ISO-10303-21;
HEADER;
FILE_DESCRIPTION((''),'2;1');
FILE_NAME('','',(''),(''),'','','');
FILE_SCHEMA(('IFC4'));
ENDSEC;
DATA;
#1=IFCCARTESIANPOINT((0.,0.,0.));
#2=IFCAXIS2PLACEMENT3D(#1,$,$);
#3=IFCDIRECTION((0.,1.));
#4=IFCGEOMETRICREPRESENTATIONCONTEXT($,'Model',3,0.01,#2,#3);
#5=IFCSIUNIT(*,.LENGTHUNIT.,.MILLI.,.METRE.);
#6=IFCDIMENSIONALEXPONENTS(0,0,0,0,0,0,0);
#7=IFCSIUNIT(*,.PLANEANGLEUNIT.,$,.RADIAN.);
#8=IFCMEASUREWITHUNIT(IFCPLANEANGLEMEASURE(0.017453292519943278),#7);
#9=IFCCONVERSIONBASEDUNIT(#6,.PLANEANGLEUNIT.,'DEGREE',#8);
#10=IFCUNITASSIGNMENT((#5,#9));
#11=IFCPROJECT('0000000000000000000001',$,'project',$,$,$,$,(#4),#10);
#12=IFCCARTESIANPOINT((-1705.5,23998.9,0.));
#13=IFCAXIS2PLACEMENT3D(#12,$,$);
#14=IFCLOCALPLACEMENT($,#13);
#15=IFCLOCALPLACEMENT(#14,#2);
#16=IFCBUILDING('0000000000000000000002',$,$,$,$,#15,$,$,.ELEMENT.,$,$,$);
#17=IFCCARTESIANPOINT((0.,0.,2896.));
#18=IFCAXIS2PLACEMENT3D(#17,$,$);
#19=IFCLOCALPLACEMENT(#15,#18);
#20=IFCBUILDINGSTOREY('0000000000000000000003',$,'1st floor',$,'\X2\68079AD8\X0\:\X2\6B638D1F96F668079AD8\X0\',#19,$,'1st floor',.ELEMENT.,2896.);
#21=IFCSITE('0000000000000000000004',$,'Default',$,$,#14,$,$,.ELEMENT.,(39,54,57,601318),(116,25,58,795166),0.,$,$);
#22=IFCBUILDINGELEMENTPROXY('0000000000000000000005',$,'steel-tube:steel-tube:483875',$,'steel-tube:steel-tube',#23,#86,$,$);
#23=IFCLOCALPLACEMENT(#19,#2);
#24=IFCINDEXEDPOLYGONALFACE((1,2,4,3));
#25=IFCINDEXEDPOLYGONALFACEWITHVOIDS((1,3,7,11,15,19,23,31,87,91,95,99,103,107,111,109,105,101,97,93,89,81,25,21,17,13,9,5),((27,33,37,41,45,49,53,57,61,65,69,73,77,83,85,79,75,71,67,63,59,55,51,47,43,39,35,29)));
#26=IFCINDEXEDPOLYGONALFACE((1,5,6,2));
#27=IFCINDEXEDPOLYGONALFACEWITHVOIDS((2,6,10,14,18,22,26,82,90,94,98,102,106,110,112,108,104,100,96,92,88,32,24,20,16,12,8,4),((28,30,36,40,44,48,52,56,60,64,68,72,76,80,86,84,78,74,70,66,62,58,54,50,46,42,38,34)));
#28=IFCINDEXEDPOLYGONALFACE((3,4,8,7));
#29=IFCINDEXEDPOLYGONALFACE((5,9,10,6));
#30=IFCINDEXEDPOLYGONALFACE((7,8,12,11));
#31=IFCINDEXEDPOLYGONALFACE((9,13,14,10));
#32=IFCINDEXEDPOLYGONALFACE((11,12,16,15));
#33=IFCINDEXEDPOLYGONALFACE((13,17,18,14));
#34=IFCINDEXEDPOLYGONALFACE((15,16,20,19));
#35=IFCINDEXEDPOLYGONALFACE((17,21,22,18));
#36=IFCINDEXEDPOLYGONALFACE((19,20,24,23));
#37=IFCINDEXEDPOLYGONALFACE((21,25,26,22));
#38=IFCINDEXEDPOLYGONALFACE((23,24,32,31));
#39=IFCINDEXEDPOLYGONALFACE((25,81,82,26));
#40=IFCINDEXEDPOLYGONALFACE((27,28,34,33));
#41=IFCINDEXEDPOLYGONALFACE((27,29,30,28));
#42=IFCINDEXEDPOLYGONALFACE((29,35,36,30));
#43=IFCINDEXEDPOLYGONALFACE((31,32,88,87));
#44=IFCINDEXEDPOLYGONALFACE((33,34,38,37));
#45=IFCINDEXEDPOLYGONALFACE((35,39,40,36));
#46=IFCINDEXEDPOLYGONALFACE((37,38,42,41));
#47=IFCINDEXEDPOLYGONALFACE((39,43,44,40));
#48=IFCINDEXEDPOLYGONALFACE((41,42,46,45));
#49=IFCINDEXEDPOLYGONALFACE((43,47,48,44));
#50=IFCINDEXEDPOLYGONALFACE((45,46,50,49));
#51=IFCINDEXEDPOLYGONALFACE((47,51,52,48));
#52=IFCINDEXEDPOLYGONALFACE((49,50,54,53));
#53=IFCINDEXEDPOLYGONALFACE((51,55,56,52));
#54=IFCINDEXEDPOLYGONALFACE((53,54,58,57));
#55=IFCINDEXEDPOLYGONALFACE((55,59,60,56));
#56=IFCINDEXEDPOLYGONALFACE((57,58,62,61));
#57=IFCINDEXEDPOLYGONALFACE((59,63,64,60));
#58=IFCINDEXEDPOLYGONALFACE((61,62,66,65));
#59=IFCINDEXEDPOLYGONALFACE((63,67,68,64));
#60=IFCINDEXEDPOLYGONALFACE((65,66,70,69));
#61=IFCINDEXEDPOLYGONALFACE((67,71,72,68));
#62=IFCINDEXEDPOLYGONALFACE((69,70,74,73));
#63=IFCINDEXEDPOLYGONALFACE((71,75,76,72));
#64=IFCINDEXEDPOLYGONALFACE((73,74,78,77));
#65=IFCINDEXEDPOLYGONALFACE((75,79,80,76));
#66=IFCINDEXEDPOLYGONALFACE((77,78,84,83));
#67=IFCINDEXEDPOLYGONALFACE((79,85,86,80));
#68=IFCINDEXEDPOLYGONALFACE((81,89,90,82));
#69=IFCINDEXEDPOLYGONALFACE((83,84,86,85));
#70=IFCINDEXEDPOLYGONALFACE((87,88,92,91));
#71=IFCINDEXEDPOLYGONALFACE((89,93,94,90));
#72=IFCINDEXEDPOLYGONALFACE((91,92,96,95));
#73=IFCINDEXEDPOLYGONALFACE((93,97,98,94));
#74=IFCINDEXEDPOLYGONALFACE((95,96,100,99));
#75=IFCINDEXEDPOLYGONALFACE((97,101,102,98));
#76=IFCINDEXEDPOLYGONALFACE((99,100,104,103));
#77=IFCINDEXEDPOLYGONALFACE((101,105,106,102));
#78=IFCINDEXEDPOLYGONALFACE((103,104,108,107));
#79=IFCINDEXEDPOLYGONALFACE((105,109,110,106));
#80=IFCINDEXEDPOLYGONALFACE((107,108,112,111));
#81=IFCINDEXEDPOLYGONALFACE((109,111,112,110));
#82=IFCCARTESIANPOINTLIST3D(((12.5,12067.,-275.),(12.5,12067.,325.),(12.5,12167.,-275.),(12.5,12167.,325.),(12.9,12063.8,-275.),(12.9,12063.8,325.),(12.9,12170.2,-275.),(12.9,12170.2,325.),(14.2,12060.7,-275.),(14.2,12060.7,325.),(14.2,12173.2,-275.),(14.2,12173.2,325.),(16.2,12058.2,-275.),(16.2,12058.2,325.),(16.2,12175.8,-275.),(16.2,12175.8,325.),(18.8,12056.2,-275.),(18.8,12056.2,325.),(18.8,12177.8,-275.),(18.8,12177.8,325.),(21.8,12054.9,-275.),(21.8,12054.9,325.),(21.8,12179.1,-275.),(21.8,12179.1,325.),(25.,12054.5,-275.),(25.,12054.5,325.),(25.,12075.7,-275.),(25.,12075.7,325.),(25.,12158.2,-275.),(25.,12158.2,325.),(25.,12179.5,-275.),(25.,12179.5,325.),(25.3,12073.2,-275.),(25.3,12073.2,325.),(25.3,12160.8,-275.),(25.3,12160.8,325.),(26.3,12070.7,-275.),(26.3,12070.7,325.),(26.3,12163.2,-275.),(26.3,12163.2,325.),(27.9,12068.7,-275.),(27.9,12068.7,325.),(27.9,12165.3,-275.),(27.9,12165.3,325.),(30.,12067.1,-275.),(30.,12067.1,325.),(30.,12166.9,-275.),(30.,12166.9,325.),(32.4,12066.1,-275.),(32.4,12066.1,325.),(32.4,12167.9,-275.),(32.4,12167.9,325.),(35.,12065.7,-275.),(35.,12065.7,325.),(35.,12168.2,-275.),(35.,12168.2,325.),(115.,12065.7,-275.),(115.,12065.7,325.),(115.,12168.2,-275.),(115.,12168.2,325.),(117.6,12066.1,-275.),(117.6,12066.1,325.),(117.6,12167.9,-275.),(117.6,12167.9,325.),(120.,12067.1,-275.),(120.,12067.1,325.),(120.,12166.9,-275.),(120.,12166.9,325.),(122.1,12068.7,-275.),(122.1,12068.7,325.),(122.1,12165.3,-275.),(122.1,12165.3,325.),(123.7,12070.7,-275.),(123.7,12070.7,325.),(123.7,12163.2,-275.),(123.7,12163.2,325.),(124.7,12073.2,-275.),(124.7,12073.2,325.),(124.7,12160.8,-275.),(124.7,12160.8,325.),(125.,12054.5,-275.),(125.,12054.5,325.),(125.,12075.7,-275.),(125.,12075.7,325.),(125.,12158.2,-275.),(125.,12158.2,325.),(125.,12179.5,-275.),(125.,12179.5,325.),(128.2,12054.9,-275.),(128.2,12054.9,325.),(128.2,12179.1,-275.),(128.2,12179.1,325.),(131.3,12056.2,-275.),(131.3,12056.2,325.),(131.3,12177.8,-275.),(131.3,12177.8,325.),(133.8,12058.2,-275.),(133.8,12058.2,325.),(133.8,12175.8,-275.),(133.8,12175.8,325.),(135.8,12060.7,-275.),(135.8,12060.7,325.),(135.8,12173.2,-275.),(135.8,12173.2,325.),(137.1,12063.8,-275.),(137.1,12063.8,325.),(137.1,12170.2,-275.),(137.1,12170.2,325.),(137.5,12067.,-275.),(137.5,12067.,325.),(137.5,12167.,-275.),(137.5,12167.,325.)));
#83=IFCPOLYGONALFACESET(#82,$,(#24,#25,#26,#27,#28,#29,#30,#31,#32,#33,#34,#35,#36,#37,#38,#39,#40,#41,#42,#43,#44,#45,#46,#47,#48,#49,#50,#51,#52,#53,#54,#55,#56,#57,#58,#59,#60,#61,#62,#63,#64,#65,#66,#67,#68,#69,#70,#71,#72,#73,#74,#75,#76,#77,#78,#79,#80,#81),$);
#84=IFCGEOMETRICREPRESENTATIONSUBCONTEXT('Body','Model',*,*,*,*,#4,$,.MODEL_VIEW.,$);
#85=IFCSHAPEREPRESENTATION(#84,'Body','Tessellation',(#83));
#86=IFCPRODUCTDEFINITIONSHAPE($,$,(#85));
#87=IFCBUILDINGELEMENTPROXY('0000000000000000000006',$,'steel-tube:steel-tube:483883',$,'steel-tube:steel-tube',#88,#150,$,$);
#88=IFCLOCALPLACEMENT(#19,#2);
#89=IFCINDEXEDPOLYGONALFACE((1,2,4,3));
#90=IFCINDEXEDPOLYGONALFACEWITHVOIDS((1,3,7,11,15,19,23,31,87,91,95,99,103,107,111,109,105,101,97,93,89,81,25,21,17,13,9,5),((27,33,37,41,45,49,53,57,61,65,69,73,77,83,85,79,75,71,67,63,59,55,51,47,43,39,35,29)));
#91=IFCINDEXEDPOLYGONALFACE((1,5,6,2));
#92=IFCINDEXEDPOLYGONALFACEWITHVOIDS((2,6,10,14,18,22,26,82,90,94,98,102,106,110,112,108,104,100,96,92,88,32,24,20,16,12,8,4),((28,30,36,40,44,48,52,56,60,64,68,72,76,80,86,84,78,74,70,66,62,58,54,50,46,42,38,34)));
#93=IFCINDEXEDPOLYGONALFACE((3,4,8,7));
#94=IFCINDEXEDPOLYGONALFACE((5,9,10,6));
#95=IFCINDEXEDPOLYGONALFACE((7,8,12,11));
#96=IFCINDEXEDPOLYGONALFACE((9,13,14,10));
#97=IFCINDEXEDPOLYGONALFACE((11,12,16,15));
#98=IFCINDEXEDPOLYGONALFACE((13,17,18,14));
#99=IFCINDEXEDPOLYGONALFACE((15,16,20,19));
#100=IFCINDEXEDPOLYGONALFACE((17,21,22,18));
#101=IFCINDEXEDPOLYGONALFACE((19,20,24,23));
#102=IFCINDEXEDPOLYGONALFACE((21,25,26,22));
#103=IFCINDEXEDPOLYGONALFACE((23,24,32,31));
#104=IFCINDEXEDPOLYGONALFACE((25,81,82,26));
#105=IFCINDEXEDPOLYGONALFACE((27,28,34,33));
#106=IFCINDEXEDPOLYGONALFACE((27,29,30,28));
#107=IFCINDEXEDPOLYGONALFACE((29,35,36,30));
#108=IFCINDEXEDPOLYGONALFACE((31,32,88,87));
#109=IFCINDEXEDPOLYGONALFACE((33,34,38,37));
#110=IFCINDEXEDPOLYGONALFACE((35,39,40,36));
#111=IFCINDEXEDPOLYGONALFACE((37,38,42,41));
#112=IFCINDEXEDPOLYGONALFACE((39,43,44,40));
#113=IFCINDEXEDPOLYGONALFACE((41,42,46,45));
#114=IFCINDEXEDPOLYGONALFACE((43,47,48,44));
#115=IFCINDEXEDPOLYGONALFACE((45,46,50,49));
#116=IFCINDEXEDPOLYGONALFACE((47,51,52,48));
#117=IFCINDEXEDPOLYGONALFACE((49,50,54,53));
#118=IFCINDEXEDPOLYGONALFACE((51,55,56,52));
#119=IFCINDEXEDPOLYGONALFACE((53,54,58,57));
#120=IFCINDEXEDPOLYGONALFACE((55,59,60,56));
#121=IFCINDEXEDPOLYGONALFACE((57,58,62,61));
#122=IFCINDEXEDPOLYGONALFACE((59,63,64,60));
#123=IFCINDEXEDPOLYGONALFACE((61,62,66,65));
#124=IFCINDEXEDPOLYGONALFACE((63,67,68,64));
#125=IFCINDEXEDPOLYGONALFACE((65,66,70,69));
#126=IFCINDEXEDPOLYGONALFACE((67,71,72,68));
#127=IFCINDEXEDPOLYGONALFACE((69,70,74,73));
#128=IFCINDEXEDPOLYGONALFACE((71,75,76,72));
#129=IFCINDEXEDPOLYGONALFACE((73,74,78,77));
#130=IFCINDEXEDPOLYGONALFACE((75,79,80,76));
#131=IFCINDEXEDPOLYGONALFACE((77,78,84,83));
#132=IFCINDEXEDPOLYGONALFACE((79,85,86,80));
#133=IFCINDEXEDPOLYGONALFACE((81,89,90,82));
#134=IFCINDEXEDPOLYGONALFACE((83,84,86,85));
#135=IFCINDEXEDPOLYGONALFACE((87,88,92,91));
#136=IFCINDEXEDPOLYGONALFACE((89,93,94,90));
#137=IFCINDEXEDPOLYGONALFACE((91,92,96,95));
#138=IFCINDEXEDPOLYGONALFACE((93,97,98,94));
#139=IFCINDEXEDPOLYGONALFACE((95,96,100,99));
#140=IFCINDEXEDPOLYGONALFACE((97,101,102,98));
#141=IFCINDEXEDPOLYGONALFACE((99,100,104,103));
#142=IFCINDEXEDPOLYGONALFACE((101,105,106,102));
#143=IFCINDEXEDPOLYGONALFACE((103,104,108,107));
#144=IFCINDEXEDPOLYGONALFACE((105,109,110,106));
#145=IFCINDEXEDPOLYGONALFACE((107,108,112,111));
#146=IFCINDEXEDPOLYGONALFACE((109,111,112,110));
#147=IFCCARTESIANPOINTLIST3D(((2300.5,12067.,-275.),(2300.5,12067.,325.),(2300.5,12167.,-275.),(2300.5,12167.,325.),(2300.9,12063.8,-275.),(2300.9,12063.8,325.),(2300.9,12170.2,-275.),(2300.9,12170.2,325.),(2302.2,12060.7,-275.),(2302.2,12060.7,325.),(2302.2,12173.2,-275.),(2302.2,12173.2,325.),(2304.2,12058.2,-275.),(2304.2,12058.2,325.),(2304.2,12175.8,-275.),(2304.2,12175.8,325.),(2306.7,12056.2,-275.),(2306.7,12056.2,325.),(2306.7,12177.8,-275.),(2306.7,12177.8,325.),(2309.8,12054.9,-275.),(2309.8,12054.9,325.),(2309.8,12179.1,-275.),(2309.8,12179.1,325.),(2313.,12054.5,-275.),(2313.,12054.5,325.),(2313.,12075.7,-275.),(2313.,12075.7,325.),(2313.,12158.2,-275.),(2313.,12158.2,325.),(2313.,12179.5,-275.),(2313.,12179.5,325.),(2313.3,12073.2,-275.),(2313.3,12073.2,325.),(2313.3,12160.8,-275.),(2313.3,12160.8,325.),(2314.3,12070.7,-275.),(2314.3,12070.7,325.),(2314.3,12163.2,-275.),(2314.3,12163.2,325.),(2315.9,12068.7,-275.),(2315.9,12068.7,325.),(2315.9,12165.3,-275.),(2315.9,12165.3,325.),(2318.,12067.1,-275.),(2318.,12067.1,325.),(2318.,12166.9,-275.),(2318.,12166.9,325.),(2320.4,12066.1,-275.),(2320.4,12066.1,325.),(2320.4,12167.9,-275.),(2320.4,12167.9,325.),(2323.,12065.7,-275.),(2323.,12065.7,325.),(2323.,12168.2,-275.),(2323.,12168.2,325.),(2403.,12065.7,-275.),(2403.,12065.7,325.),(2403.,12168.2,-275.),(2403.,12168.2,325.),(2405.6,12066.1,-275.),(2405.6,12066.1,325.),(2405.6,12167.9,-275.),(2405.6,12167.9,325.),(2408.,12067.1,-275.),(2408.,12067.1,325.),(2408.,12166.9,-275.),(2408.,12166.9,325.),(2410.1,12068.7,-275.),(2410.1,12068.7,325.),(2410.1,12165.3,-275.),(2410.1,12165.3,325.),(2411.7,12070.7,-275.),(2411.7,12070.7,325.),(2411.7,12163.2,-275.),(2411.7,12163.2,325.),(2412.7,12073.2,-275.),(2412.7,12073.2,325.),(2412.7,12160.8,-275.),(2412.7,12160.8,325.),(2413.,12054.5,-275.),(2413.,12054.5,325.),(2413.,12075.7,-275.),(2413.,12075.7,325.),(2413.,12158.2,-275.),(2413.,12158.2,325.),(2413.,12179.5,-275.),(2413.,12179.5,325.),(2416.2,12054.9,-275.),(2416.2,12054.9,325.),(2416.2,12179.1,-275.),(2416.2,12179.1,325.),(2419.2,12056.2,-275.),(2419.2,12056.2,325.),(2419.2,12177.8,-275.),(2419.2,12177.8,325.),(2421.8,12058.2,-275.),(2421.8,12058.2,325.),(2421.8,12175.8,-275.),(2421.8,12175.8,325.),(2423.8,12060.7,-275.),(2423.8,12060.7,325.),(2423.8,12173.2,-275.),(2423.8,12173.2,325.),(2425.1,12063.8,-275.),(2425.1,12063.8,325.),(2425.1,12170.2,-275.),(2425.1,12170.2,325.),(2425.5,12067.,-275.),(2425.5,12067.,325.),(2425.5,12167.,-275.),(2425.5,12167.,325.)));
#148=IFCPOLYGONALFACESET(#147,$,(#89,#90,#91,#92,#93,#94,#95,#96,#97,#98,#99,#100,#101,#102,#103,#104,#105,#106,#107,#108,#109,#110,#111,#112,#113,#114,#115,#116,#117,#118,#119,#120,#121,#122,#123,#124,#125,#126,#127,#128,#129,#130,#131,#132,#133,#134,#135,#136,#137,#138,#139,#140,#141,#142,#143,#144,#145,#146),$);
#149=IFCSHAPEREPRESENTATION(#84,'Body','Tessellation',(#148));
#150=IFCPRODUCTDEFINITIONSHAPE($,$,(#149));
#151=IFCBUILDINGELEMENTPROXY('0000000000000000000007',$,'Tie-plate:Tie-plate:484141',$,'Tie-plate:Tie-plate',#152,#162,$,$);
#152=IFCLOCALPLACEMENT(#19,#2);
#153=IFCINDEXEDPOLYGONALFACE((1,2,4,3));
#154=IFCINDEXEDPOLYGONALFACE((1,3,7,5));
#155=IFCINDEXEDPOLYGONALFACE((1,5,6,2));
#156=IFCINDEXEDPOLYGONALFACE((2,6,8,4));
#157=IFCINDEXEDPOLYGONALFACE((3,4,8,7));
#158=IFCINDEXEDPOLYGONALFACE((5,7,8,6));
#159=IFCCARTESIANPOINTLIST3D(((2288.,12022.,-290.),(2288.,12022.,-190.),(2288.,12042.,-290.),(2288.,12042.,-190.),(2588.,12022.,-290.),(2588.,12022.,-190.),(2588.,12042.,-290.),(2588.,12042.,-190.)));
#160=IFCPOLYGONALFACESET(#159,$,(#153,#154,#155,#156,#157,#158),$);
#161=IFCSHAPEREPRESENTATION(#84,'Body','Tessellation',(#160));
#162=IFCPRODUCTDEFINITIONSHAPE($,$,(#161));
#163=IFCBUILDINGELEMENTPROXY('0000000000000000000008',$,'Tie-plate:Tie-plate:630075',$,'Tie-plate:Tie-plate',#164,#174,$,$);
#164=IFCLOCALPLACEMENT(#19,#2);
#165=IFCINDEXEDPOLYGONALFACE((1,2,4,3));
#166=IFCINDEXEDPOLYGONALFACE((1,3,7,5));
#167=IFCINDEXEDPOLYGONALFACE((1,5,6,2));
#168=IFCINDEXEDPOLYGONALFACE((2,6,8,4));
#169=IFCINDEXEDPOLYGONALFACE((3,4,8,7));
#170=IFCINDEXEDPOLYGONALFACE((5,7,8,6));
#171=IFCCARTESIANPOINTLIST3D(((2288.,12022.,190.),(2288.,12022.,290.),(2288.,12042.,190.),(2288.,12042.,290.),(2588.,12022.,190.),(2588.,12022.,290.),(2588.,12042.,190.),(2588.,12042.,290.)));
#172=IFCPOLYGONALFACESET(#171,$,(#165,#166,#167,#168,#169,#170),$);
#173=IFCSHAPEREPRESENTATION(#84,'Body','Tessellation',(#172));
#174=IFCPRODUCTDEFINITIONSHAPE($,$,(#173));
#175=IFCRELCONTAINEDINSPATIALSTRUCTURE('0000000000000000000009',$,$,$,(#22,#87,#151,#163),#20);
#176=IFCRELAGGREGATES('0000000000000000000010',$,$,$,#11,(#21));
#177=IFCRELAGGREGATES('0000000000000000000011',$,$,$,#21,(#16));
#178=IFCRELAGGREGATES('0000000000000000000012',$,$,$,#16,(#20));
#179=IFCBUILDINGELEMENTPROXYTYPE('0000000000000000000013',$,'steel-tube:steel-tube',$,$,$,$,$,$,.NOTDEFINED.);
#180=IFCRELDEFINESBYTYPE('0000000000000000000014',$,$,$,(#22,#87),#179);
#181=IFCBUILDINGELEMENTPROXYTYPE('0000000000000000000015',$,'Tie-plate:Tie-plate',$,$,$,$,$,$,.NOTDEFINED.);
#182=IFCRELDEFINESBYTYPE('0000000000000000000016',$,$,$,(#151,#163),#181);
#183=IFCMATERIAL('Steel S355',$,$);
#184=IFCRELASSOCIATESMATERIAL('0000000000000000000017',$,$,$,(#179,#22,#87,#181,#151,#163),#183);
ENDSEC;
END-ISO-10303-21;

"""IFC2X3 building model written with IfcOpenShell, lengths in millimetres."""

from ifc_helpers import new_model, entity, si_unit, converted_unit, direction, frame, frame_2d, origin, place, context, subcontext, project, spatial, polyline, circle_curve, parameter, trimmed, segment, composite_curve, rectangle, outline, extrude, source, transform, mapped, material, type_object, type_shapes, element, save


model = new_model("IFC2X3")

# Units and contexts
model_context = context("Model", 3, precision=0.01, world=origin(), true_north=direction((0.0, 1.0)))
body_context = subcontext(model_context, "Body", "Model", "MODEL_VIEW")
ifc_project = project(units=[si_unit("LENGTHUNIT", "METRE", prefix="MILLI"), converted_unit("PLANEANGLEUNIT", "DEGREE", entity("IfcPlaneAngleMeasure", 0.017453292519943278), si_unit("PLANEANGLEUNIT", "RADIAN"), dimensions=[0, 0, 0, 0, 0, 0, 0])], contexts=[model_context])

# Site, building, storey
site_placement = place(None, frame((-1705.5, 23998.9, 0.0)))
site = spatial("IfcSite", under=ifc_project, at=site_placement, Name="Default", CompositionType="ELEMENT", RefLatitude=(39, 54, 57, 601318), RefLongitude=(116, 25, 58, 795166), RefElevation=0.0)
building_placement = place(site_placement, origin())
building = spatial("IfcBuilding", under=site, at=building_placement, CompositionType="ELEMENT")
storey_placement = place(building_placement, frame((0.0, 0.0, 2896.0)))
storey = spatial("IfcBuildingStorey", under=building, at=storey_placement, Name="1st floor", ObjectType="标高:正负零标高", LongName="1st floor", CompositionType="ELEMENT", Elevation=2896.0)

# Shared definitions
ifc_material_1 = material(Name="Steel S355")

# Building element proxies
building_element_proxy_type_1 = type_object("IfcBuildingElementProxyType", Name="steel-tube:steel-tube", PredefinedType="NOTDEFINED", material=ifc_material_1)
shared_shape_1 = source(origin(), body_context, "Body", "SweptSolid", [
    extrude(outline(composite_curve([segment(trimmed(circle_curve(frame_2d((50.0, -50.0), x_axis=(1.0, 0.0)), 12.5), [parameter(270.0)], [parameter(0.0)], True, "PARAMETER"), True, "CONTINUOUS"), segment(polyline([(62.5, -50.0), (62.5, 50.0)]), True, "CONTINUOUS"), segment(trimmed(circle_curve(frame_2d((50.0, 50.0), x_axis=(1.0, 0.0)), 12.5), [parameter(0.0)], [parameter(90.0)], True, "PARAMETER"), True, "CONTINUOUS"), segment(polyline([(50.0, 62.5), (-50.0, 62.5)]), True, "CONTINUOUS"), segment(trimmed(circle_curve(frame_2d((-50.0, 50.0), x_axis=(1.0, 0.0)), 12.5), [parameter(90.0)], [parameter(180.0)], True, "PARAMETER"), True, "CONTINUOUS"), segment(polyline([(-62.5, 50.0), (-62.5, -50.0)]), True, "CONTINUOUS"), segment(trimmed(circle_curve(frame_2d((-50.0, -50.0), x_axis=(1.0, 0.0)), 12.5), [parameter(180.0)], [parameter(270.0)], True, "PARAMETER"), True, "CONTINUOUS"), segment(polyline([(-50.0, -62.5), (50.0, -62.5)]), True, "CONTINUOUS")], self_intersect=False), holes=[composite_curve([segment(trimmed(circle_curve(frame_2d((-41.2, 40.0), x_axis=(1.0, 0.0)), 10.0), [parameter(90.0)], [parameter(180.0)], True, "PARAMETER"), False, "CONTINUOUS"), segment(polyline([(-41.3, 50.0), (41.2, 50.0)]), True, "CONTINUOUS"), segment(trimmed(circle_curve(frame_2d((41.2, 40.0), x_axis=(1.0, 0.0)), 10.0), [parameter(0.0)], [parameter(90.0)], True, "PARAMETER"), False, "CONTINUOUS"), segment(polyline([(51.2, 40.0), (51.2, -40.0)]), True, "CONTINUOUS"), segment(trimmed(circle_curve(frame_2d((41.2, -40.0), x_axis=(1.0, 0.0)), 10.0), [parameter(270.0)], [parameter(360.0)], True, "PARAMETER"), False, "CONTINUOUS"), segment(polyline([(41.2, -50.0), (-41.3, -50.0)]), True, "CONTINUOUS"), segment(trimmed(circle_curve(frame_2d((-41.3, -40.0), x_axis=(1.0, 0.0)), 10.0), [parameter(180.0)], [parameter(270.0)], True, "PARAMETER"), False, "CONTINUOUS"), segment(polyline([(-51.3, -40.0), (-51.3, 40.0)]), True, "CONTINUOUS")], self_intersect=False)]), frame((62.5, 62.5, -175.0)), (0.0, 0.0, 1.0), 600.0),
])
type_shapes(building_element_proxy_type_1, [shared_shape_1])
for number, where, z_axis, x_axis, name in (
    (1, (12.5, 12179.5, -100.0), (0.0, 0.0, 1.0), (0.0, -1.0, 0.0), "steel-tube:steel-tube:483875"),
    (2, (2300.5, 12179.5, -100.0), (0.0, 0.0, 1.0), (0.0, -1.0, 0.0), "steel-tube:steel-tube:483883"),
):
    element("IfcBuildingElementProxy", number, at=place(storey_placement, frame(where, z_axis=z_axis, x_axis=x_axis)), inside=storey, type_object=building_element_proxy_type_1, material=ifc_material_1, Name=name, ObjectType="steel-tube:steel-tube", context=body_context, shape_type="MappedRepresentation", body=[
        mapped(shared_shape_1, transform((0.0, 0.0, 0.0), scale=1.0)),
    ])
building_element_proxy_type_2 = type_object("IfcBuildingElementProxyType", Name="Tie-plate:Tie-plate", PredefinedType="NOTDEFINED", material=ifc_material_1)
shared_shape_2 = source(origin(), body_context, "Body", "SweptSolid", [
    extrude(rectangle(XDim=300.0, YDim=20.0, at=frame_2d((0.0, 0.0), x_axis=(1.0, 0.0))), frame((150.0, -10.0, 0.0), z_axis=(0.0, 0.0, 1.0), x_axis=(-1.0, 0.0, 0.0)), (0.0, 0.0, 1.0), 100.0),
])
type_shapes(building_element_proxy_type_2, [shared_shape_2])
for number, where, name in (
    (3, (2288.0, 12042.0, -290.0), "Tie-plate:Tie-plate:484141"),
    (4, (2288.0, 12042.0, 190.0), "Tie-plate:Tie-plate:630075"),
):
    element("IfcBuildingElementProxy", number, at=place(storey_placement, frame(where)), inside=storey, type_object=building_element_proxy_type_2, material=ifc_material_1, Name=name, ObjectType="Tie-plate:Tie-plate", context=body_context, shape_type="MappedRepresentation", body=[
        mapped(shared_shape_2, transform((0.0, 0.0, 0.0), scale=1.0)),
    ])

save(model, "model.ifc")
